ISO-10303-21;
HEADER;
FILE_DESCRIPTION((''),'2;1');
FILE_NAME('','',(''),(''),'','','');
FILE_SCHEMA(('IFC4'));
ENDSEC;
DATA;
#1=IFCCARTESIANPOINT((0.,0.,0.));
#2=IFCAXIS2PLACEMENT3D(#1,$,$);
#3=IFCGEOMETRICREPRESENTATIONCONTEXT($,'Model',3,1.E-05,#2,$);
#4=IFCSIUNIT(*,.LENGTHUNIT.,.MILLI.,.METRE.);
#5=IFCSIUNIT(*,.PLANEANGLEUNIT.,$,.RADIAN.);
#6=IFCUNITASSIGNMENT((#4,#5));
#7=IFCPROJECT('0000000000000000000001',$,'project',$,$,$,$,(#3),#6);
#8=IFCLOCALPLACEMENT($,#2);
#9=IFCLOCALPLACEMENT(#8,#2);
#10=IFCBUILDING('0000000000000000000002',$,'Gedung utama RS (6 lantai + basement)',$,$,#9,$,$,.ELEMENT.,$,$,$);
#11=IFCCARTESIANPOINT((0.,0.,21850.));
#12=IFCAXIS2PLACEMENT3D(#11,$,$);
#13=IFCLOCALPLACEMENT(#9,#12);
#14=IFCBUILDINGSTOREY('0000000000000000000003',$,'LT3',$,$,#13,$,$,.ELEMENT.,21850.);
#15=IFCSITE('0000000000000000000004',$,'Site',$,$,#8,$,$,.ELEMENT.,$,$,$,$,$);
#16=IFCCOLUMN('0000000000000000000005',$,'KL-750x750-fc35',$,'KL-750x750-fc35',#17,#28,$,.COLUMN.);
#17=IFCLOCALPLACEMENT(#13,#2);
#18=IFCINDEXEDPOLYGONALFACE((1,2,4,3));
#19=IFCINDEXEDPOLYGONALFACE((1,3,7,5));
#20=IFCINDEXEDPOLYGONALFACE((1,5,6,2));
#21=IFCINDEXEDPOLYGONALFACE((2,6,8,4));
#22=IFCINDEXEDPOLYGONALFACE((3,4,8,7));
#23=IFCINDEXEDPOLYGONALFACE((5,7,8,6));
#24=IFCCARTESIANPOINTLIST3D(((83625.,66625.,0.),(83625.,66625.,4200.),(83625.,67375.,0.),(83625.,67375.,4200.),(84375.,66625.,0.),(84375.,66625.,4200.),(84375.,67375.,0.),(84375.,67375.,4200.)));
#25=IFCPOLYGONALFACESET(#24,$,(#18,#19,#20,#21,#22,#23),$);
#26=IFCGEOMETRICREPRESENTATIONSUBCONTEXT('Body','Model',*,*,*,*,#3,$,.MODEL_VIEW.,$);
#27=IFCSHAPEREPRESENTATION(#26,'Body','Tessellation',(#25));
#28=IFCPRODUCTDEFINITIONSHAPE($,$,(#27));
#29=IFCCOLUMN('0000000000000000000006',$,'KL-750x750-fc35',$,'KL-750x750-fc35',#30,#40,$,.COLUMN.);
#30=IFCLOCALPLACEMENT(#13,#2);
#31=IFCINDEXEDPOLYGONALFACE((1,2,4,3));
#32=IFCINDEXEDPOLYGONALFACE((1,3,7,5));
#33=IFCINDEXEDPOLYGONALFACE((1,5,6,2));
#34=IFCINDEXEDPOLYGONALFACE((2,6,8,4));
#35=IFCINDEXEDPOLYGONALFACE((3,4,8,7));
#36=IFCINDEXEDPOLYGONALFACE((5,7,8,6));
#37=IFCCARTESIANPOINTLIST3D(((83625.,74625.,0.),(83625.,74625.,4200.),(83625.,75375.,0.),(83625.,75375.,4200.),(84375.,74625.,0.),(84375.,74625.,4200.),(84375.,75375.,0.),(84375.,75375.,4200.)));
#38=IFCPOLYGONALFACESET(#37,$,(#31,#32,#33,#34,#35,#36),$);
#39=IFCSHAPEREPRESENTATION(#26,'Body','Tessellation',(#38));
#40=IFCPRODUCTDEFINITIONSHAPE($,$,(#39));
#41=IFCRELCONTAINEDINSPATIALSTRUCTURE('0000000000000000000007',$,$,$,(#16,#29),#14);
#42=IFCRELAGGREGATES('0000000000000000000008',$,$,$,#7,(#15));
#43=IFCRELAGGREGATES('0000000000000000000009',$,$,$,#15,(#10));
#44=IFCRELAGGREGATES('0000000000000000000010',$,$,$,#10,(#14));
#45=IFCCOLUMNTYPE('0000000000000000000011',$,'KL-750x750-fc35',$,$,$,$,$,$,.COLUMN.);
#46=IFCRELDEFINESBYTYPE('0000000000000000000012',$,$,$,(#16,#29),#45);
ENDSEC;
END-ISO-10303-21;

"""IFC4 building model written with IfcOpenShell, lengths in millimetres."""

from ifc_helpers import new_model, si_unit, frame, origin, origin_2d, place, context, subcontext, project, spatial, rectangle, extrude, material_profile, profile_set, profile_usage, type_object, element, save


model = new_model("IFC4")

# Units and contexts
model_context = context("Model", 3, precision=1e-05, world=origin())
body_context = subcontext(model_context, "Body", "Model", "MODEL_VIEW")
ifc_project = project(units=[si_unit("LENGTHUNIT", "METRE", prefix="MILLI"), si_unit("PLANEANGLEUNIT", "RADIAN")], contexts=[model_context])

# Site, building, storey
site_placement = place(None, origin())
site = spatial("IfcSite", under=ifc_project, at=site_placement, Name="Site", CompositionType="ELEMENT")
building_placement = place(site_placement, origin())
building = spatial("IfcBuilding", under=site, at=building_placement, Name="Gedung utama RS (6 lantai + basement)", CompositionType="ELEMENT")
storey_placement = place(building_placement, frame((0.0, 0.0, 21850.0)))
storey = spatial("IfcBuildingStorey", under=building, at=storey_placement, Name="LT3", CompositionType="ELEMENT", Elevation=21850.0)

# Columns
ifc_material_profile = material_profile(None, rectangle(XDim=750.0, YDim=750.0, at=origin_2d()), Name="KL-750x750-fc35")
ifc_profile_set = profile_set([ifc_material_profile], Name="KL-750x750-fc35")
ifc_profile_usage = profile_usage(ifc_profile_set, cardinal=5)
column_type = type_object("IfcColumnType", Name="KL-750x750-fc35", PredefinedType="COLUMN", material=ifc_profile_set)
for number, where, z_axis, x_axis, name in (
    (1, (84000.0, 67000.0, 0.0), (0.0, 0.0, 1.0), (1.0, 0.0, 0.0), "KL-750x750-fc35"),
    (2, (84000.0, 75000.0, 0.0), (0.0, 0.0, 1.0), (1.0, 0.0, 0.0), "KL-750x750-fc35"),
):
    element("IfcColumn", number, at=place(storey_placement, frame(where, z_axis=z_axis, x_axis=x_axis)), inside=storey, type_object=column_type, material=ifc_profile_usage, Name=name, ObjectType="KL-750x750-fc35", PredefinedType="COLUMN", context=body_context, shape_type="SweptSolid", body=[
        extrude(rectangle(XDim=750.0, YDim=750.0, at=origin_2d()), origin(), (0.0, 0.0, 1.0), 4200.0),
    ])

save(model, "model.ifc")
